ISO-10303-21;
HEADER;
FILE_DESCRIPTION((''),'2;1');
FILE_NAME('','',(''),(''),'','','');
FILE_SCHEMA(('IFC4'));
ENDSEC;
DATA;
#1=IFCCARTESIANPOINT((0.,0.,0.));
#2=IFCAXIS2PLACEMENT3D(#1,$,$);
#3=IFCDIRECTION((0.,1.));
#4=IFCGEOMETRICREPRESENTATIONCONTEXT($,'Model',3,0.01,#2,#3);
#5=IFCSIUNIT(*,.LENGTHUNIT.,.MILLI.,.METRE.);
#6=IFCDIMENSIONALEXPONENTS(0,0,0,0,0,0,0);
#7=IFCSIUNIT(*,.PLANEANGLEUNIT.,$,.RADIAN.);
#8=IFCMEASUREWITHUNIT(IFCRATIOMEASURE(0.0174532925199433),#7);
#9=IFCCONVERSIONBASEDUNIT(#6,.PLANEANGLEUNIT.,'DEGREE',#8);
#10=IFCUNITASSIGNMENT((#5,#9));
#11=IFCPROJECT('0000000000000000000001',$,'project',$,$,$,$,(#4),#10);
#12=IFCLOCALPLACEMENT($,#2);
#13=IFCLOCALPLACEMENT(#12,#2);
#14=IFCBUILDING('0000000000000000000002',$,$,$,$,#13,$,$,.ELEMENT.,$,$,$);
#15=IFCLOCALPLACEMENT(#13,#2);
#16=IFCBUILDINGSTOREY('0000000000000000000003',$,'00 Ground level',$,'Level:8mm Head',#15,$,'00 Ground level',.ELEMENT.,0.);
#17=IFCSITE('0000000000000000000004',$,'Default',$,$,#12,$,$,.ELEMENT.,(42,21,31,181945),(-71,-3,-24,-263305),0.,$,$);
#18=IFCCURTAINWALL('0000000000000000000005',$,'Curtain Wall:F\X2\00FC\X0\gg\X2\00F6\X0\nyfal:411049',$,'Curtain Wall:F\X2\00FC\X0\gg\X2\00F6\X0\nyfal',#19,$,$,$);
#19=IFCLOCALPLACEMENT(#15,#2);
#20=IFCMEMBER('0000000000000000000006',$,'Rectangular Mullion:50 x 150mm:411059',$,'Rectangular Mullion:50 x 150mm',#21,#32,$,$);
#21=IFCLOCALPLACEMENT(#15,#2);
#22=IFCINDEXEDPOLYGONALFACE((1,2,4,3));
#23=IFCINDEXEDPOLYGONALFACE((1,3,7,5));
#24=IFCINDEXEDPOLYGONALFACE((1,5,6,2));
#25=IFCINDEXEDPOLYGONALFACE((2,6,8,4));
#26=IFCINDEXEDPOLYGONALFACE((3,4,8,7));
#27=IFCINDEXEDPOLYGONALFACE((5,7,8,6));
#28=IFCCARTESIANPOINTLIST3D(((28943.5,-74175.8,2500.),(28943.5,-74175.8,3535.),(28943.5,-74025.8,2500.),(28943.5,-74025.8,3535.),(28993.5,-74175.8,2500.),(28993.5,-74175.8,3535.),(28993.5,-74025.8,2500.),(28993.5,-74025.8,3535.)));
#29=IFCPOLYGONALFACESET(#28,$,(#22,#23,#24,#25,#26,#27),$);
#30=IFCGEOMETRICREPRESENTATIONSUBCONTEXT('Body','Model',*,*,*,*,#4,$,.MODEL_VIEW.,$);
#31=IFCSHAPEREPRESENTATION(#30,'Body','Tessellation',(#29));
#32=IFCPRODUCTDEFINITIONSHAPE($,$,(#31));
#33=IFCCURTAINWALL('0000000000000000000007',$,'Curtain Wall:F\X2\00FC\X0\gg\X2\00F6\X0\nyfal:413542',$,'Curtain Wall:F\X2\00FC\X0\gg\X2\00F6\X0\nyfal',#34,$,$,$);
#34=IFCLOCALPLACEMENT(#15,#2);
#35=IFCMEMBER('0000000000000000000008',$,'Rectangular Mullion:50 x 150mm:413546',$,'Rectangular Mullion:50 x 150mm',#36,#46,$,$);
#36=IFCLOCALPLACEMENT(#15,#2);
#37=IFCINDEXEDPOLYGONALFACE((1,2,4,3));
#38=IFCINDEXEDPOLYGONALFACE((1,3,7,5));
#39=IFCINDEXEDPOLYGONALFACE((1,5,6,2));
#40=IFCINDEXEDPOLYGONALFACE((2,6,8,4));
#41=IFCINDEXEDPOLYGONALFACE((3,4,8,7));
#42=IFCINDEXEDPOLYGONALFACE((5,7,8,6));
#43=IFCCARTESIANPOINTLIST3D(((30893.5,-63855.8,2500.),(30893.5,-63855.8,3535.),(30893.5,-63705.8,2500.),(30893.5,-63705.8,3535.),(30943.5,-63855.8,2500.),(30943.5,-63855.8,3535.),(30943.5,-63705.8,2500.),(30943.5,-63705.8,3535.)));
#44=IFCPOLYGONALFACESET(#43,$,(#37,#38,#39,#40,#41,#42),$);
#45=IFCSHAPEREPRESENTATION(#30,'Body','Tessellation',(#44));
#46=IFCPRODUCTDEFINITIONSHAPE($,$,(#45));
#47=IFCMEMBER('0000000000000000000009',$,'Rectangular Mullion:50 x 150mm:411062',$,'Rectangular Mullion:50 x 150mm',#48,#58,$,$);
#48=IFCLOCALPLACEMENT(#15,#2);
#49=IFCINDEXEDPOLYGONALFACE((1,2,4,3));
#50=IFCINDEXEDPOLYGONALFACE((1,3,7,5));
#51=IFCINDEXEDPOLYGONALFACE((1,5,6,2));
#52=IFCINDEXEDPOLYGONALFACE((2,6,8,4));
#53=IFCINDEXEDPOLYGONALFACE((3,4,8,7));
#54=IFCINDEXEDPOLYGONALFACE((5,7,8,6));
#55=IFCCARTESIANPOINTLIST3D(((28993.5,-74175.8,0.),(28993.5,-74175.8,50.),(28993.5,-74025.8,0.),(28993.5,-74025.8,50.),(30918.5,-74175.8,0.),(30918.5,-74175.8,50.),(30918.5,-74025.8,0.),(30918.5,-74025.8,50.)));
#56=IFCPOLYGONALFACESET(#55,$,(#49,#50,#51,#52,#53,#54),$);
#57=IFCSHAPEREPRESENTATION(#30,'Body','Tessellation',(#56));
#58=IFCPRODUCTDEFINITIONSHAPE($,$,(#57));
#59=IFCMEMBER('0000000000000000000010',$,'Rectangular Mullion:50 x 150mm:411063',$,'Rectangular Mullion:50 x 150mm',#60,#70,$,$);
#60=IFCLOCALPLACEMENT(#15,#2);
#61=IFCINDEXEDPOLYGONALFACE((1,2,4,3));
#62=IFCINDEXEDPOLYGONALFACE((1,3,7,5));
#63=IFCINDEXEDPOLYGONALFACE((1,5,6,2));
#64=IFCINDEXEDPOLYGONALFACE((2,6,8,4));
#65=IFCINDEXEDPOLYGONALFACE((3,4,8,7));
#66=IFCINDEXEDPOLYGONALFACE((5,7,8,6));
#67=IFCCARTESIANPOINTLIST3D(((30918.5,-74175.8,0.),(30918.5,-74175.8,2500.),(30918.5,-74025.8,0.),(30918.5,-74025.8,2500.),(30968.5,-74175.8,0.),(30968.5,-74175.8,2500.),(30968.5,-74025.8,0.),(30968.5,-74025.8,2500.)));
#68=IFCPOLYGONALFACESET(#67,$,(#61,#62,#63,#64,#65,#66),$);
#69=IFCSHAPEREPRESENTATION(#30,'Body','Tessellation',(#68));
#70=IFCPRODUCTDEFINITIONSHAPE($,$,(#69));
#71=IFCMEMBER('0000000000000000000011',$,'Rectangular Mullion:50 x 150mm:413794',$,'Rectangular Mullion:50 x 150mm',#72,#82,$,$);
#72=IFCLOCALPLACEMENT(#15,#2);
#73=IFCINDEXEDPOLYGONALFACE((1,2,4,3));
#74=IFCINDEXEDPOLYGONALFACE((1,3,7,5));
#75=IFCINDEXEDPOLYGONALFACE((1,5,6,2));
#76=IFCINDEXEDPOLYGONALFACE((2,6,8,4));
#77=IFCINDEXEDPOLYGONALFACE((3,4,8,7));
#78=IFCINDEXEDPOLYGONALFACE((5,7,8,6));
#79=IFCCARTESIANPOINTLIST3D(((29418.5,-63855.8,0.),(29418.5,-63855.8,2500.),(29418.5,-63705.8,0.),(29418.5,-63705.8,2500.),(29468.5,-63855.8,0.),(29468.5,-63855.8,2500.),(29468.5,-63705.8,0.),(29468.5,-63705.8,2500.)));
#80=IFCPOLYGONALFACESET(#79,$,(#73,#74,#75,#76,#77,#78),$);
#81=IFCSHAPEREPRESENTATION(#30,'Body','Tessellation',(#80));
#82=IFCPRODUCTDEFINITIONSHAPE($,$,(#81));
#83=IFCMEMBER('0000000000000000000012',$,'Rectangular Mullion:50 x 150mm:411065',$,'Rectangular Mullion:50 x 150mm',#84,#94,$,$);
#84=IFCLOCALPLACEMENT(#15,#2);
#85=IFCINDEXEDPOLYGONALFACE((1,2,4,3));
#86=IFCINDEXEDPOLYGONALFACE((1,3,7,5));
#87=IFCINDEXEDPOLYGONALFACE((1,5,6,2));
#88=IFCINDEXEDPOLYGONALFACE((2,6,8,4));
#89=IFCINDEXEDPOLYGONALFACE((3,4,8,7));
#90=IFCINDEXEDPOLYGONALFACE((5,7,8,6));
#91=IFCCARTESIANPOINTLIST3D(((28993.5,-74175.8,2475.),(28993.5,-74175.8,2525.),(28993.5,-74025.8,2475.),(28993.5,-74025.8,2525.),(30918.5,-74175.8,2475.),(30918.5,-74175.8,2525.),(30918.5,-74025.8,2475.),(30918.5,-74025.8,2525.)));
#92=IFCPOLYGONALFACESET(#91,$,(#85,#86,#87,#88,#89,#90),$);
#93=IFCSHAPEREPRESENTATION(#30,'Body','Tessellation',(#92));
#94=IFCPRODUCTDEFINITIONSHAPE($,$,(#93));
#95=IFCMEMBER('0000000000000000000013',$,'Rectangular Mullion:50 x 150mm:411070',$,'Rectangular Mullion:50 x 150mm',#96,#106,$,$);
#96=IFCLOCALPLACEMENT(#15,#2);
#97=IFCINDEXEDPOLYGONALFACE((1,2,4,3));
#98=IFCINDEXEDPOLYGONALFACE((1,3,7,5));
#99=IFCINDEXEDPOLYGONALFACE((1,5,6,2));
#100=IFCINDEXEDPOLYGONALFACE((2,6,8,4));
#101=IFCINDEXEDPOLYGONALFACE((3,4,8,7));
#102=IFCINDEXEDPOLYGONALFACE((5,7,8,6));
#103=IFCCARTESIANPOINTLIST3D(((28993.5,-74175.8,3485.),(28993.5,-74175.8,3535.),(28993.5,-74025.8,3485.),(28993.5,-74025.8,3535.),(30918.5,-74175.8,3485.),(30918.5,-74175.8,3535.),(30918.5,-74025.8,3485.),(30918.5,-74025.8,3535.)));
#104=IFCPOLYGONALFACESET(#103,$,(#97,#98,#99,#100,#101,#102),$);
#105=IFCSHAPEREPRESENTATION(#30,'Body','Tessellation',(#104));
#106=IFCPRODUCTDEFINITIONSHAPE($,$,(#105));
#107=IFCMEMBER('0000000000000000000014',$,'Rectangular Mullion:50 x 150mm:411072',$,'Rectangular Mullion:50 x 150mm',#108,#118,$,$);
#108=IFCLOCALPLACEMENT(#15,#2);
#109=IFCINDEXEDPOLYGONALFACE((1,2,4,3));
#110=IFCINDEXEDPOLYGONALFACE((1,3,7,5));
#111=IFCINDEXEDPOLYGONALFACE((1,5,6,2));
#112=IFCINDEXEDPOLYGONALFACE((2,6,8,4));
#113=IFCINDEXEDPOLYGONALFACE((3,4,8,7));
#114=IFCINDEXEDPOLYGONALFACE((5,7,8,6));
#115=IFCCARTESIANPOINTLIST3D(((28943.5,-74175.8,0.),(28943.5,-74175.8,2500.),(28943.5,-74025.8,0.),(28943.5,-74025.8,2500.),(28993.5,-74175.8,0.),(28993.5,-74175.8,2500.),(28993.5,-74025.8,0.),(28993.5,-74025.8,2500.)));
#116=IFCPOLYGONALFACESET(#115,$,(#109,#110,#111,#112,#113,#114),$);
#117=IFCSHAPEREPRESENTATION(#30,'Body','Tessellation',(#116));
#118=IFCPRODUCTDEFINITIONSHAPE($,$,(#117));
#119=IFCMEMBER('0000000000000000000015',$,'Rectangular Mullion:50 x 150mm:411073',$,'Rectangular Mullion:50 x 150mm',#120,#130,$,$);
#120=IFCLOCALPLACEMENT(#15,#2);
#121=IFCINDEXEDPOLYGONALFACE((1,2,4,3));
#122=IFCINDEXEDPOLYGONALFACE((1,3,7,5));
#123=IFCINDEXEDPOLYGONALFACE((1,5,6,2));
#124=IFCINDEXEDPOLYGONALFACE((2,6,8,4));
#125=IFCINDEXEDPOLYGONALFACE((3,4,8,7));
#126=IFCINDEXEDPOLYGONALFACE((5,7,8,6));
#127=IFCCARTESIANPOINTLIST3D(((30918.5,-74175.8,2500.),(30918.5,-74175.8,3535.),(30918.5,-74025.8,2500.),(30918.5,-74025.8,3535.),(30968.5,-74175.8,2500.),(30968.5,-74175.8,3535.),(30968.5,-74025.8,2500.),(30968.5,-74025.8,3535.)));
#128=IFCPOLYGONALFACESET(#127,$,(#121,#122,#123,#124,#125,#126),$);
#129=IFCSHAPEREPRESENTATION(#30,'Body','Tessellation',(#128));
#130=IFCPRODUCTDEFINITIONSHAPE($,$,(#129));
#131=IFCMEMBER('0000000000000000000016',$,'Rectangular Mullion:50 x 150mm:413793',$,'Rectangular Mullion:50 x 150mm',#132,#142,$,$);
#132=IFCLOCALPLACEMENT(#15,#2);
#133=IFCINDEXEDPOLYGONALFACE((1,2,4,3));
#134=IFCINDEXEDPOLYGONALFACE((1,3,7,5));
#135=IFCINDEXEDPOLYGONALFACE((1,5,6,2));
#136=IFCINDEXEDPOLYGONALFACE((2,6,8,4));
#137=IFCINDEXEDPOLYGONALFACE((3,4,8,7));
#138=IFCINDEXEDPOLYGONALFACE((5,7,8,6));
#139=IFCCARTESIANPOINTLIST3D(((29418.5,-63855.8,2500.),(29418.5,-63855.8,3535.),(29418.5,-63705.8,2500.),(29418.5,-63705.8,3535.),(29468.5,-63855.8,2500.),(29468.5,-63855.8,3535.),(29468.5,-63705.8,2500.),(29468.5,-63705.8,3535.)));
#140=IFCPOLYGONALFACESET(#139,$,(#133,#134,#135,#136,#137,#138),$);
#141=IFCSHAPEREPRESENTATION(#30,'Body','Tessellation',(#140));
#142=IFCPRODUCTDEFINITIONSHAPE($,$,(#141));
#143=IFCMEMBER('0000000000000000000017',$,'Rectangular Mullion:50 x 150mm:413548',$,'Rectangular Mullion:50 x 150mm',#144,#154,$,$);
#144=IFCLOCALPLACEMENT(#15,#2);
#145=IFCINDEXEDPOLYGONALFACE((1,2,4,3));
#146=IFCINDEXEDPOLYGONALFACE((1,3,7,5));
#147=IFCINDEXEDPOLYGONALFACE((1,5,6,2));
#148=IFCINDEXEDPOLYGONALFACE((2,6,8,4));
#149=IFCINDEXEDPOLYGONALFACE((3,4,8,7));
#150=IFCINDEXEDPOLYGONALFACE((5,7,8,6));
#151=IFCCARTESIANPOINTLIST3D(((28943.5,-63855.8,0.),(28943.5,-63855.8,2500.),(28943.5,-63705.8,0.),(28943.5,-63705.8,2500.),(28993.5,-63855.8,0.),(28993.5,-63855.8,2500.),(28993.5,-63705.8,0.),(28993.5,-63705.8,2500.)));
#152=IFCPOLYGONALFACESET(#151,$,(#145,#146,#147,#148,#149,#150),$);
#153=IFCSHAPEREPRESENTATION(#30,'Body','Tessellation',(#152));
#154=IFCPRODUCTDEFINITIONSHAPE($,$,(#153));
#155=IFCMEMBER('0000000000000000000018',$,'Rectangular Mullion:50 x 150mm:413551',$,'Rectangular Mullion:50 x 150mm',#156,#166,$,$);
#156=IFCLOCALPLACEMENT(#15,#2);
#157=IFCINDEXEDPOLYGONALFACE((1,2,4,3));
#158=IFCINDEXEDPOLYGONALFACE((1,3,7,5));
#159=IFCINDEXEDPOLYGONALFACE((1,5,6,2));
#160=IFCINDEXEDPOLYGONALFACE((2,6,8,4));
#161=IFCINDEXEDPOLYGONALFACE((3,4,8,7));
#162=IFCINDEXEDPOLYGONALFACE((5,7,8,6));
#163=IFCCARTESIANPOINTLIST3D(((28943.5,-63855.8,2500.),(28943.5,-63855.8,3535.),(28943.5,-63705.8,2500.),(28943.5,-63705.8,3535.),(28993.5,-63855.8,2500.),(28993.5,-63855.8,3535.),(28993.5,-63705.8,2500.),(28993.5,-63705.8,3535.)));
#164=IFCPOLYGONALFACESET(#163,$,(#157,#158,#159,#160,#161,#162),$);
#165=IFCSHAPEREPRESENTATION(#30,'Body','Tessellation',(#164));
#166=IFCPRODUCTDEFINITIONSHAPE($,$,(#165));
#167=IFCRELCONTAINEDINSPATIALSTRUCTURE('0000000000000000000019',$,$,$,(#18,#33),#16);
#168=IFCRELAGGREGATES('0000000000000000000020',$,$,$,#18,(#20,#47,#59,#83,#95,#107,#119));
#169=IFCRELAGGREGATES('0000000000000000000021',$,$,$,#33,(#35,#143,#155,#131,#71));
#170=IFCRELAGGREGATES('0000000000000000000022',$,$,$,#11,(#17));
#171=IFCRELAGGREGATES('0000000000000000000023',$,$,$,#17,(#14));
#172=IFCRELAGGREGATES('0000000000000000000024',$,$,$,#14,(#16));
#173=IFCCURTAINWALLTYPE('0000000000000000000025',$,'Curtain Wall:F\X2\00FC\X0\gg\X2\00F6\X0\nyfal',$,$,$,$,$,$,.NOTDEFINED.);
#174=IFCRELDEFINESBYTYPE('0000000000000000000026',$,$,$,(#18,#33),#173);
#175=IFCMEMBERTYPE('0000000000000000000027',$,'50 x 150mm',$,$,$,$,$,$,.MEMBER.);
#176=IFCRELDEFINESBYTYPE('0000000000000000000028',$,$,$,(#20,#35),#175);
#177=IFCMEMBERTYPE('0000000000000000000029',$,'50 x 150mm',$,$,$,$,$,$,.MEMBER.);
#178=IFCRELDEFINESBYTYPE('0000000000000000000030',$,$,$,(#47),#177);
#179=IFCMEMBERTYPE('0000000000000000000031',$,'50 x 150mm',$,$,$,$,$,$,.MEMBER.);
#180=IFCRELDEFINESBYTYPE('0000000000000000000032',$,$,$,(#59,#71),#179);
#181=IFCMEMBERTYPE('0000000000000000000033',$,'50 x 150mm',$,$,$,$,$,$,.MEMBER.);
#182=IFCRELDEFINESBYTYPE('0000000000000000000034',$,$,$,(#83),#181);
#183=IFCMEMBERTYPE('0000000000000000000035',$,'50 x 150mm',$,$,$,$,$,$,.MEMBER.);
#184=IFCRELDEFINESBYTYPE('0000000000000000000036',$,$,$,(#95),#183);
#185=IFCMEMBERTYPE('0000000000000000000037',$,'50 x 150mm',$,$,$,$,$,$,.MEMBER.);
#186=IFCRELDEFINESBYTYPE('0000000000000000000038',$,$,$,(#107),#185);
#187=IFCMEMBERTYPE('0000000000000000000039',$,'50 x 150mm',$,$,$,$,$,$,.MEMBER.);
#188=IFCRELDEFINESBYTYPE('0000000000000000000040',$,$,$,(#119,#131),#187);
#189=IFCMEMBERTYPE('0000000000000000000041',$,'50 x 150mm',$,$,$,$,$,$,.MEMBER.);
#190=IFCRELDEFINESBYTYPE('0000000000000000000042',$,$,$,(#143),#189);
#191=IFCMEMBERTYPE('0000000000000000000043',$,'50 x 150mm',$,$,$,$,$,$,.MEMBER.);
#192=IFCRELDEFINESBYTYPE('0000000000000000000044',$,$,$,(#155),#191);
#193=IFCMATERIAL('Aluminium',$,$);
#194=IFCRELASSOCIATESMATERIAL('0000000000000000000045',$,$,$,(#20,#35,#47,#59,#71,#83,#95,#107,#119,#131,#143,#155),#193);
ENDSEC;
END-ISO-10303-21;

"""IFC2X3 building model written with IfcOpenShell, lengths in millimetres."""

from ifc_helpers import new_model, entity, si_unit, converted_unit, direction, frame, origin, origin_2d_with_axis, place, context, subcontext, project, spatial, rectangle, extrude, source, transform, mapped, material, type_object, type_shapes, element, aggregate, save


model = new_model("IFC2X3")

# Units and contexts
model_context = context("Model", 3, precision=0.01, world=origin(), true_north=direction((0.0, 1.0)))
body_context = subcontext(model_context, "Body", "Model", "MODEL_VIEW")
ifc_project = project(units=[si_unit("LENGTHUNIT", "METRE", prefix="MILLI"), converted_unit("PLANEANGLEUNIT", "DEGREE", entity("IfcRatioMeasure", 0.0174532925199433), si_unit("PLANEANGLEUNIT", "RADIAN"), dimensions=[0, 0, 0, 0, 0, 0, 0])], contexts=[model_context])

# Site, building, storey
site_placement = place(None, origin())
site = spatial("IfcSite", under=ifc_project, at=site_placement, Name="Default", CompositionType="ELEMENT", RefLatitude=(42, 21, 31, 181945), RefLongitude=(-71, -3, -24, -263305), RefElevation=0.0)
building_placement = place(site_placement, origin())
building = spatial("IfcBuilding", under=site, at=building_placement, CompositionType="ELEMENT")
storey_placement = place(building_placement, origin())
storey = spatial("IfcBuildingStorey", under=building, at=storey_placement, Name="00 Ground level", ObjectType="Level:8mm Head", LongName="00 Ground level", CompositionType="ELEMENT", Elevation=0.0)

# Curtain walls, members
curtain_wall_type = type_object("IfcCurtainWallType", Name="Curtain Wall:Függönyfal", PredefinedType="NOTDEFINED")
curtain_wall_1_placement = place(storey_placement, origin())
curtain_wall_1 = element("IfcCurtainWall", 1, at=curtain_wall_1_placement, inside=storey, type_object=curtain_wall_type, Name="Curtain Wall:Függönyfal:411049", ObjectType="Curtain Wall:Függönyfal")
ifc_material_1 = material(Name="Aluminium")
member_type_1 = type_object("IfcMemberType", Name="50 x 150mm", PredefinedType="MEMBER")
shared_shape_1 = source(origin(), body_context, "Body", "SweptSolid", [
    extrude(rectangle(XDim=150.0, YDim=50.0, at=origin_2d_with_axis()), frame((-25.0, 0.0, -1035.0), z_axis=(0.0, 0.0, 1.0), x_axis=(0.0, -1.0, 0.0)), (0.0, 0.0, 1.0), 1035.0),
])
type_shapes(member_type_1, [shared_shape_1])
member_1_placement = place(storey_placement, frame((28943.5, -74100.8, 3535.0), z_axis=(0.0, 0.0, 1.0), x_axis=(-1.0, 0.0, 0.0)))
member_1 = element("IfcMember", 2, at=member_1_placement, type_object=member_type_1, material=ifc_material_1, Name="Rectangular Mullion:50 x 150mm:411059", ObjectType="Rectangular Mullion:50 x 150mm", context=body_context, shape_type="MappedRepresentation", body=[
    mapped(shared_shape_1, transform((0.0, 0.0, 0.0), scale=1.0)),
])
curtain_wall_2_placement = place(storey_placement, origin())
curtain_wall_2 = element("IfcCurtainWall", 3, at=curtain_wall_2_placement, inside=storey, type_object=curtain_wall_type, Name="Curtain Wall:Függönyfal:413542", ObjectType="Curtain Wall:Függönyfal")
member_2_placement = place(storey_placement, frame((30943.5, -63780.8, 3535.0)))
member_2 = element("IfcMember", 4, at=member_2_placement, type_object=member_type_1, material=ifc_material_1, Name="Rectangular Mullion:50 x 150mm:413546", ObjectType="Rectangular Mullion:50 x 150mm", context=body_context, shape_type="MappedRepresentation", body=[
    mapped(shared_shape_1, transform((0.0, 0.0, 0.0), scale=1.0)),
])

# Members
member_type_2 = type_object("IfcMemberType", Name="50 x 150mm", PredefinedType="MEMBER")
shared_shape_2 = source(origin(), body_context, "Body", "SweptSolid", [
    extrude(rectangle(XDim=150.0, YDim=50.0, at=origin_2d_with_axis()), frame((-25.0, 0.0, -1925.0), z_axis=(0.0, 0.0, 1.0), x_axis=(0.0, -1.0, 0.0)), (0.0, 0.0, 1.0), 1925.0),
])
type_shapes(member_type_2, [shared_shape_2])
member_3_placement = place(storey_placement, frame((28993.5, -74100.8, 0.0), z_axis=(-1.0, 0.0, 0.0), x_axis=(0.0, 0.0, -1.0)))
member_3 = element("IfcMember", 5, at=member_3_placement, type_object=member_type_2, material=ifc_material_1, Name="Rectangular Mullion:50 x 150mm:411062", ObjectType="Rectangular Mullion:50 x 150mm", context=body_context, shape_type="MappedRepresentation", body=[
    mapped(shared_shape_2, transform((0.0, 0.0, 0.0), scale=1.0)),
])
member_type_3 = type_object("IfcMemberType", Name="50 x 150mm", PredefinedType="MEMBER")
shared_shape_3 = source(origin(), body_context, "Body", "SweptSolid", [
    extrude(rectangle(XDim=150.0, YDim=50.0, at=origin_2d_with_axis()), frame((0.0, 0.0, -2500.0), z_axis=(0.0, 0.0, 1.0), x_axis=(0.0, -1.0, 0.0)), (0.0, 0.0, 1.0), 2500.0),
])
type_shapes(member_type_3, [shared_shape_3])
member_4_placement = place(storey_placement, frame((30943.5, -74100.8, 0.0), z_axis=(0.0, 0.0, -1.0), x_axis=(1.0, 0.0, 0.0)))
member_4 = element("IfcMember", 6, at=member_4_placement, type_object=member_type_3, material=ifc_material_1, Name="Rectangular Mullion:50 x 150mm:411063", ObjectType="Rectangular Mullion:50 x 150mm", context=body_context, shape_type="MappedRepresentation", body=[
    mapped(shared_shape_3, transform((0.0, 0.0, 0.0), scale=1.0)),
])
member_5_placement = place(storey_placement, frame((29443.5, -63780.8, 0.0), z_axis=(0.0, 0.0, -1.0), x_axis=(-1.0, 0.0, 0.0)))
member_5 = element("IfcMember", 7, at=member_5_placement, type_object=member_type_3, material=ifc_material_1, Name="Rectangular Mullion:50 x 150mm:413794", ObjectType="Rectangular Mullion:50 x 150mm", context=body_context, shape_type="MappedRepresentation", body=[
    mapped(shared_shape_3, transform((0.0, 0.0, 0.0), scale=1.0)),
])
member_type_4 = type_object("IfcMemberType", Name="50 x 150mm", PredefinedType="MEMBER")
shared_shape_4 = source(origin(), body_context, "Body", "SweptSolid", [
    extrude(rectangle(XDim=150.0, YDim=50.0, at=origin_2d_with_axis()), frame((0.0, 0.0, -1925.0), z_axis=(0.0, 0.0, 1.0), x_axis=(0.0, -1.0, 0.0)), (0.0, 0.0, 1.0), 1925.0),
])
type_shapes(member_type_4, [shared_shape_4])
member_6_placement = place(storey_placement, frame((30918.5, -74100.8, 2500.0), z_axis=(1.0, 0.0, 0.0), x_axis=(0.0, 0.0, 1.0)))
member_6 = element("IfcMember", 8, at=member_6_placement, type_object=member_type_4, material=ifc_material_1, Name="Rectangular Mullion:50 x 150mm:411065", ObjectType="Rectangular Mullion:50 x 150mm", context=body_context, shape_type="MappedRepresentation", body=[
    mapped(shared_shape_4, transform((0.0, 0.0, 0.0), scale=1.0)),
])
member_type_5 = type_object("IfcMemberType", Name="50 x 150mm", PredefinedType="MEMBER")
shared_shape_5 = source(origin(), body_context, "Body", "SweptSolid", [
    extrude(rectangle(XDim=150.0, YDim=50.0, at=origin_2d_with_axis()), frame((-25.0, 0.0, -1925.0), z_axis=(0.0, 0.0, 1.0), x_axis=(0.0, -1.0, 0.0)), (0.0, 0.0, 1.0), 1925.0),
])
type_shapes(member_type_5, [shared_shape_5])
member_7_placement = place(storey_placement, frame((30918.5, -74100.8, 3535.0), z_axis=(1.0, 0.0, 0.0), x_axis=(0.0, 0.0, 1.0)))
member_7 = element("IfcMember", 9, at=member_7_placement, type_object=member_type_5, material=ifc_material_1, Name="Rectangular Mullion:50 x 150mm:411070", ObjectType="Rectangular Mullion:50 x 150mm", context=body_context, shape_type="MappedRepresentation", body=[
    mapped(shared_shape_5, transform((0.0, 0.0, 0.0), scale=1.0)),
])
member_type_6 = type_object("IfcMemberType", Name="50 x 150mm", PredefinedType="MEMBER")
shared_shape_6 = source(origin(), body_context, "Body", "SweptSolid", [
    extrude(rectangle(XDim=150.0, YDim=50.0, at=origin_2d_with_axis()), frame((-25.0, 0.0, -2500.0), z_axis=(0.0, 0.0, 1.0), x_axis=(0.0, -1.0, 0.0)), (0.0, 0.0, 1.0), 2500.0),
])
type_shapes(member_type_6, [shared_shape_6])
member_8_placement = place(storey_placement, frame((28943.5, -74100.8, 2500.0), z_axis=(0.0, 0.0, 1.0), x_axis=(-1.0, 0.0, 0.0)))
member_8 = element("IfcMember", 10, at=member_8_placement, type_object=member_type_6, material=ifc_material_1, Name="Rectangular Mullion:50 x 150mm:411072", ObjectType="Rectangular Mullion:50 x 150mm", context=body_context, shape_type="MappedRepresentation", body=[
    mapped(shared_shape_6, transform((0.0, 0.0, 0.0), scale=1.0)),
])
member_type_7 = type_object("IfcMemberType", Name="50 x 150mm", PredefinedType="MEMBER")
shared_shape_7 = source(origin(), body_context, "Body", "SweptSolid", [
    extrude(rectangle(XDim=150.0, YDim=50.0, at=origin_2d_with_axis()), frame((0.0, 0.0, -1035.0), z_axis=(0.0, 0.0, 1.0), x_axis=(0.0, -1.0, 0.0)), (0.0, 0.0, 1.0), 1035.0),
])
type_shapes(member_type_7, [shared_shape_7])
member_9_placement = place(storey_placement, frame((30943.5, -74100.8, 2500.0), z_axis=(0.0, 0.0, -1.0), x_axis=(1.0, 0.0, 0.0)))
member_9 = element("IfcMember", 11, at=member_9_placement, type_object=member_type_7, material=ifc_material_1, Name="Rectangular Mullion:50 x 150mm:411073", ObjectType="Rectangular Mullion:50 x 150mm", context=body_context, shape_type="MappedRepresentation", body=[
    mapped(shared_shape_7, transform((0.0, 0.0, 0.0), scale=1.0)),
])
member_10_placement = place(storey_placement, frame((29443.5, -63780.8, 2500.0), z_axis=(0.0, 0.0, -1.0), x_axis=(-1.0, 0.0, 0.0)))
member_10 = element("IfcMember", 12, at=member_10_placement, type_object=member_type_7, material=ifc_material_1, Name="Rectangular Mullion:50 x 150mm:413793", ObjectType="Rectangular Mullion:50 x 150mm", context=body_context, shape_type="MappedRepresentation", body=[
    mapped(shared_shape_7, transform((0.0, 0.0, 0.0), scale=1.0)),
])
member_type_8 = type_object("IfcMemberType", Name="50 x 150mm", PredefinedType="MEMBER")
shared_shape_8 = source(origin(), body_context, "Body", "SweptSolid", [
    extrude(rectangle(XDim=150.0, YDim=50.0, at=origin_2d_with_axis()), frame((-25.0, 0.0, -2500.0), z_axis=(0.0, 0.0, 1.0), x_axis=(0.0, -1.0, 0.0)), (0.0, 0.0, 1.0), 2500.0),
])
type_shapes(member_type_8, [shared_shape_8])
member_11_placement = place(storey_placement, frame((28943.5, -63780.8, 0.0), z_axis=(0.0, 0.0, -1.0), x_axis=(-1.0, 0.0, 0.0)))
member_11 = element("IfcMember", 13, at=member_11_placement, type_object=member_type_8, material=ifc_material_1, Name="Rectangular Mullion:50 x 150mm:413548", ObjectType="Rectangular Mullion:50 x 150mm", context=body_context, shape_type="MappedRepresentation", body=[
    mapped(shared_shape_8, transform((0.0, 0.0, 0.0), scale=1.0)),
])
member_type_9 = type_object("IfcMemberType", Name="50 x 150mm", PredefinedType="MEMBER")
shared_shape_9 = source(origin(), body_context, "Body", "SweptSolid", [
    extrude(rectangle(XDim=150.0, YDim=50.0, at=origin_2d_with_axis()), frame((-25.0, 0.0, -1035.0), z_axis=(0.0, 0.0, 1.0), x_axis=(0.0, -1.0, 0.0)), (0.0, 0.0, 1.0), 1035.0),
])
type_shapes(member_type_9, [shared_shape_9])
member_12_placement = place(storey_placement, frame((28943.5, -63780.8, 2500.0), z_axis=(0.0, 0.0, -1.0), x_axis=(-1.0, 0.0, 0.0)))
member_12 = element("IfcMember", 14, at=member_12_placement, type_object=member_type_9, material=ifc_material_1, Name="Rectangular Mullion:50 x 150mm:413551", ObjectType="Rectangular Mullion:50 x 150mm", context=body_context, shape_type="MappedRepresentation", body=[
    mapped(shared_shape_9, transform((0.0, 0.0, 0.0), scale=1.0)),
])

aggregate(curtain_wall_1, [member_1, member_3, member_4, member_6, member_7, member_8, member_9])

aggregate(curtain_wall_2, [member_2, member_11, member_12, member_10, member_5])

save(model, "model.ifc")
